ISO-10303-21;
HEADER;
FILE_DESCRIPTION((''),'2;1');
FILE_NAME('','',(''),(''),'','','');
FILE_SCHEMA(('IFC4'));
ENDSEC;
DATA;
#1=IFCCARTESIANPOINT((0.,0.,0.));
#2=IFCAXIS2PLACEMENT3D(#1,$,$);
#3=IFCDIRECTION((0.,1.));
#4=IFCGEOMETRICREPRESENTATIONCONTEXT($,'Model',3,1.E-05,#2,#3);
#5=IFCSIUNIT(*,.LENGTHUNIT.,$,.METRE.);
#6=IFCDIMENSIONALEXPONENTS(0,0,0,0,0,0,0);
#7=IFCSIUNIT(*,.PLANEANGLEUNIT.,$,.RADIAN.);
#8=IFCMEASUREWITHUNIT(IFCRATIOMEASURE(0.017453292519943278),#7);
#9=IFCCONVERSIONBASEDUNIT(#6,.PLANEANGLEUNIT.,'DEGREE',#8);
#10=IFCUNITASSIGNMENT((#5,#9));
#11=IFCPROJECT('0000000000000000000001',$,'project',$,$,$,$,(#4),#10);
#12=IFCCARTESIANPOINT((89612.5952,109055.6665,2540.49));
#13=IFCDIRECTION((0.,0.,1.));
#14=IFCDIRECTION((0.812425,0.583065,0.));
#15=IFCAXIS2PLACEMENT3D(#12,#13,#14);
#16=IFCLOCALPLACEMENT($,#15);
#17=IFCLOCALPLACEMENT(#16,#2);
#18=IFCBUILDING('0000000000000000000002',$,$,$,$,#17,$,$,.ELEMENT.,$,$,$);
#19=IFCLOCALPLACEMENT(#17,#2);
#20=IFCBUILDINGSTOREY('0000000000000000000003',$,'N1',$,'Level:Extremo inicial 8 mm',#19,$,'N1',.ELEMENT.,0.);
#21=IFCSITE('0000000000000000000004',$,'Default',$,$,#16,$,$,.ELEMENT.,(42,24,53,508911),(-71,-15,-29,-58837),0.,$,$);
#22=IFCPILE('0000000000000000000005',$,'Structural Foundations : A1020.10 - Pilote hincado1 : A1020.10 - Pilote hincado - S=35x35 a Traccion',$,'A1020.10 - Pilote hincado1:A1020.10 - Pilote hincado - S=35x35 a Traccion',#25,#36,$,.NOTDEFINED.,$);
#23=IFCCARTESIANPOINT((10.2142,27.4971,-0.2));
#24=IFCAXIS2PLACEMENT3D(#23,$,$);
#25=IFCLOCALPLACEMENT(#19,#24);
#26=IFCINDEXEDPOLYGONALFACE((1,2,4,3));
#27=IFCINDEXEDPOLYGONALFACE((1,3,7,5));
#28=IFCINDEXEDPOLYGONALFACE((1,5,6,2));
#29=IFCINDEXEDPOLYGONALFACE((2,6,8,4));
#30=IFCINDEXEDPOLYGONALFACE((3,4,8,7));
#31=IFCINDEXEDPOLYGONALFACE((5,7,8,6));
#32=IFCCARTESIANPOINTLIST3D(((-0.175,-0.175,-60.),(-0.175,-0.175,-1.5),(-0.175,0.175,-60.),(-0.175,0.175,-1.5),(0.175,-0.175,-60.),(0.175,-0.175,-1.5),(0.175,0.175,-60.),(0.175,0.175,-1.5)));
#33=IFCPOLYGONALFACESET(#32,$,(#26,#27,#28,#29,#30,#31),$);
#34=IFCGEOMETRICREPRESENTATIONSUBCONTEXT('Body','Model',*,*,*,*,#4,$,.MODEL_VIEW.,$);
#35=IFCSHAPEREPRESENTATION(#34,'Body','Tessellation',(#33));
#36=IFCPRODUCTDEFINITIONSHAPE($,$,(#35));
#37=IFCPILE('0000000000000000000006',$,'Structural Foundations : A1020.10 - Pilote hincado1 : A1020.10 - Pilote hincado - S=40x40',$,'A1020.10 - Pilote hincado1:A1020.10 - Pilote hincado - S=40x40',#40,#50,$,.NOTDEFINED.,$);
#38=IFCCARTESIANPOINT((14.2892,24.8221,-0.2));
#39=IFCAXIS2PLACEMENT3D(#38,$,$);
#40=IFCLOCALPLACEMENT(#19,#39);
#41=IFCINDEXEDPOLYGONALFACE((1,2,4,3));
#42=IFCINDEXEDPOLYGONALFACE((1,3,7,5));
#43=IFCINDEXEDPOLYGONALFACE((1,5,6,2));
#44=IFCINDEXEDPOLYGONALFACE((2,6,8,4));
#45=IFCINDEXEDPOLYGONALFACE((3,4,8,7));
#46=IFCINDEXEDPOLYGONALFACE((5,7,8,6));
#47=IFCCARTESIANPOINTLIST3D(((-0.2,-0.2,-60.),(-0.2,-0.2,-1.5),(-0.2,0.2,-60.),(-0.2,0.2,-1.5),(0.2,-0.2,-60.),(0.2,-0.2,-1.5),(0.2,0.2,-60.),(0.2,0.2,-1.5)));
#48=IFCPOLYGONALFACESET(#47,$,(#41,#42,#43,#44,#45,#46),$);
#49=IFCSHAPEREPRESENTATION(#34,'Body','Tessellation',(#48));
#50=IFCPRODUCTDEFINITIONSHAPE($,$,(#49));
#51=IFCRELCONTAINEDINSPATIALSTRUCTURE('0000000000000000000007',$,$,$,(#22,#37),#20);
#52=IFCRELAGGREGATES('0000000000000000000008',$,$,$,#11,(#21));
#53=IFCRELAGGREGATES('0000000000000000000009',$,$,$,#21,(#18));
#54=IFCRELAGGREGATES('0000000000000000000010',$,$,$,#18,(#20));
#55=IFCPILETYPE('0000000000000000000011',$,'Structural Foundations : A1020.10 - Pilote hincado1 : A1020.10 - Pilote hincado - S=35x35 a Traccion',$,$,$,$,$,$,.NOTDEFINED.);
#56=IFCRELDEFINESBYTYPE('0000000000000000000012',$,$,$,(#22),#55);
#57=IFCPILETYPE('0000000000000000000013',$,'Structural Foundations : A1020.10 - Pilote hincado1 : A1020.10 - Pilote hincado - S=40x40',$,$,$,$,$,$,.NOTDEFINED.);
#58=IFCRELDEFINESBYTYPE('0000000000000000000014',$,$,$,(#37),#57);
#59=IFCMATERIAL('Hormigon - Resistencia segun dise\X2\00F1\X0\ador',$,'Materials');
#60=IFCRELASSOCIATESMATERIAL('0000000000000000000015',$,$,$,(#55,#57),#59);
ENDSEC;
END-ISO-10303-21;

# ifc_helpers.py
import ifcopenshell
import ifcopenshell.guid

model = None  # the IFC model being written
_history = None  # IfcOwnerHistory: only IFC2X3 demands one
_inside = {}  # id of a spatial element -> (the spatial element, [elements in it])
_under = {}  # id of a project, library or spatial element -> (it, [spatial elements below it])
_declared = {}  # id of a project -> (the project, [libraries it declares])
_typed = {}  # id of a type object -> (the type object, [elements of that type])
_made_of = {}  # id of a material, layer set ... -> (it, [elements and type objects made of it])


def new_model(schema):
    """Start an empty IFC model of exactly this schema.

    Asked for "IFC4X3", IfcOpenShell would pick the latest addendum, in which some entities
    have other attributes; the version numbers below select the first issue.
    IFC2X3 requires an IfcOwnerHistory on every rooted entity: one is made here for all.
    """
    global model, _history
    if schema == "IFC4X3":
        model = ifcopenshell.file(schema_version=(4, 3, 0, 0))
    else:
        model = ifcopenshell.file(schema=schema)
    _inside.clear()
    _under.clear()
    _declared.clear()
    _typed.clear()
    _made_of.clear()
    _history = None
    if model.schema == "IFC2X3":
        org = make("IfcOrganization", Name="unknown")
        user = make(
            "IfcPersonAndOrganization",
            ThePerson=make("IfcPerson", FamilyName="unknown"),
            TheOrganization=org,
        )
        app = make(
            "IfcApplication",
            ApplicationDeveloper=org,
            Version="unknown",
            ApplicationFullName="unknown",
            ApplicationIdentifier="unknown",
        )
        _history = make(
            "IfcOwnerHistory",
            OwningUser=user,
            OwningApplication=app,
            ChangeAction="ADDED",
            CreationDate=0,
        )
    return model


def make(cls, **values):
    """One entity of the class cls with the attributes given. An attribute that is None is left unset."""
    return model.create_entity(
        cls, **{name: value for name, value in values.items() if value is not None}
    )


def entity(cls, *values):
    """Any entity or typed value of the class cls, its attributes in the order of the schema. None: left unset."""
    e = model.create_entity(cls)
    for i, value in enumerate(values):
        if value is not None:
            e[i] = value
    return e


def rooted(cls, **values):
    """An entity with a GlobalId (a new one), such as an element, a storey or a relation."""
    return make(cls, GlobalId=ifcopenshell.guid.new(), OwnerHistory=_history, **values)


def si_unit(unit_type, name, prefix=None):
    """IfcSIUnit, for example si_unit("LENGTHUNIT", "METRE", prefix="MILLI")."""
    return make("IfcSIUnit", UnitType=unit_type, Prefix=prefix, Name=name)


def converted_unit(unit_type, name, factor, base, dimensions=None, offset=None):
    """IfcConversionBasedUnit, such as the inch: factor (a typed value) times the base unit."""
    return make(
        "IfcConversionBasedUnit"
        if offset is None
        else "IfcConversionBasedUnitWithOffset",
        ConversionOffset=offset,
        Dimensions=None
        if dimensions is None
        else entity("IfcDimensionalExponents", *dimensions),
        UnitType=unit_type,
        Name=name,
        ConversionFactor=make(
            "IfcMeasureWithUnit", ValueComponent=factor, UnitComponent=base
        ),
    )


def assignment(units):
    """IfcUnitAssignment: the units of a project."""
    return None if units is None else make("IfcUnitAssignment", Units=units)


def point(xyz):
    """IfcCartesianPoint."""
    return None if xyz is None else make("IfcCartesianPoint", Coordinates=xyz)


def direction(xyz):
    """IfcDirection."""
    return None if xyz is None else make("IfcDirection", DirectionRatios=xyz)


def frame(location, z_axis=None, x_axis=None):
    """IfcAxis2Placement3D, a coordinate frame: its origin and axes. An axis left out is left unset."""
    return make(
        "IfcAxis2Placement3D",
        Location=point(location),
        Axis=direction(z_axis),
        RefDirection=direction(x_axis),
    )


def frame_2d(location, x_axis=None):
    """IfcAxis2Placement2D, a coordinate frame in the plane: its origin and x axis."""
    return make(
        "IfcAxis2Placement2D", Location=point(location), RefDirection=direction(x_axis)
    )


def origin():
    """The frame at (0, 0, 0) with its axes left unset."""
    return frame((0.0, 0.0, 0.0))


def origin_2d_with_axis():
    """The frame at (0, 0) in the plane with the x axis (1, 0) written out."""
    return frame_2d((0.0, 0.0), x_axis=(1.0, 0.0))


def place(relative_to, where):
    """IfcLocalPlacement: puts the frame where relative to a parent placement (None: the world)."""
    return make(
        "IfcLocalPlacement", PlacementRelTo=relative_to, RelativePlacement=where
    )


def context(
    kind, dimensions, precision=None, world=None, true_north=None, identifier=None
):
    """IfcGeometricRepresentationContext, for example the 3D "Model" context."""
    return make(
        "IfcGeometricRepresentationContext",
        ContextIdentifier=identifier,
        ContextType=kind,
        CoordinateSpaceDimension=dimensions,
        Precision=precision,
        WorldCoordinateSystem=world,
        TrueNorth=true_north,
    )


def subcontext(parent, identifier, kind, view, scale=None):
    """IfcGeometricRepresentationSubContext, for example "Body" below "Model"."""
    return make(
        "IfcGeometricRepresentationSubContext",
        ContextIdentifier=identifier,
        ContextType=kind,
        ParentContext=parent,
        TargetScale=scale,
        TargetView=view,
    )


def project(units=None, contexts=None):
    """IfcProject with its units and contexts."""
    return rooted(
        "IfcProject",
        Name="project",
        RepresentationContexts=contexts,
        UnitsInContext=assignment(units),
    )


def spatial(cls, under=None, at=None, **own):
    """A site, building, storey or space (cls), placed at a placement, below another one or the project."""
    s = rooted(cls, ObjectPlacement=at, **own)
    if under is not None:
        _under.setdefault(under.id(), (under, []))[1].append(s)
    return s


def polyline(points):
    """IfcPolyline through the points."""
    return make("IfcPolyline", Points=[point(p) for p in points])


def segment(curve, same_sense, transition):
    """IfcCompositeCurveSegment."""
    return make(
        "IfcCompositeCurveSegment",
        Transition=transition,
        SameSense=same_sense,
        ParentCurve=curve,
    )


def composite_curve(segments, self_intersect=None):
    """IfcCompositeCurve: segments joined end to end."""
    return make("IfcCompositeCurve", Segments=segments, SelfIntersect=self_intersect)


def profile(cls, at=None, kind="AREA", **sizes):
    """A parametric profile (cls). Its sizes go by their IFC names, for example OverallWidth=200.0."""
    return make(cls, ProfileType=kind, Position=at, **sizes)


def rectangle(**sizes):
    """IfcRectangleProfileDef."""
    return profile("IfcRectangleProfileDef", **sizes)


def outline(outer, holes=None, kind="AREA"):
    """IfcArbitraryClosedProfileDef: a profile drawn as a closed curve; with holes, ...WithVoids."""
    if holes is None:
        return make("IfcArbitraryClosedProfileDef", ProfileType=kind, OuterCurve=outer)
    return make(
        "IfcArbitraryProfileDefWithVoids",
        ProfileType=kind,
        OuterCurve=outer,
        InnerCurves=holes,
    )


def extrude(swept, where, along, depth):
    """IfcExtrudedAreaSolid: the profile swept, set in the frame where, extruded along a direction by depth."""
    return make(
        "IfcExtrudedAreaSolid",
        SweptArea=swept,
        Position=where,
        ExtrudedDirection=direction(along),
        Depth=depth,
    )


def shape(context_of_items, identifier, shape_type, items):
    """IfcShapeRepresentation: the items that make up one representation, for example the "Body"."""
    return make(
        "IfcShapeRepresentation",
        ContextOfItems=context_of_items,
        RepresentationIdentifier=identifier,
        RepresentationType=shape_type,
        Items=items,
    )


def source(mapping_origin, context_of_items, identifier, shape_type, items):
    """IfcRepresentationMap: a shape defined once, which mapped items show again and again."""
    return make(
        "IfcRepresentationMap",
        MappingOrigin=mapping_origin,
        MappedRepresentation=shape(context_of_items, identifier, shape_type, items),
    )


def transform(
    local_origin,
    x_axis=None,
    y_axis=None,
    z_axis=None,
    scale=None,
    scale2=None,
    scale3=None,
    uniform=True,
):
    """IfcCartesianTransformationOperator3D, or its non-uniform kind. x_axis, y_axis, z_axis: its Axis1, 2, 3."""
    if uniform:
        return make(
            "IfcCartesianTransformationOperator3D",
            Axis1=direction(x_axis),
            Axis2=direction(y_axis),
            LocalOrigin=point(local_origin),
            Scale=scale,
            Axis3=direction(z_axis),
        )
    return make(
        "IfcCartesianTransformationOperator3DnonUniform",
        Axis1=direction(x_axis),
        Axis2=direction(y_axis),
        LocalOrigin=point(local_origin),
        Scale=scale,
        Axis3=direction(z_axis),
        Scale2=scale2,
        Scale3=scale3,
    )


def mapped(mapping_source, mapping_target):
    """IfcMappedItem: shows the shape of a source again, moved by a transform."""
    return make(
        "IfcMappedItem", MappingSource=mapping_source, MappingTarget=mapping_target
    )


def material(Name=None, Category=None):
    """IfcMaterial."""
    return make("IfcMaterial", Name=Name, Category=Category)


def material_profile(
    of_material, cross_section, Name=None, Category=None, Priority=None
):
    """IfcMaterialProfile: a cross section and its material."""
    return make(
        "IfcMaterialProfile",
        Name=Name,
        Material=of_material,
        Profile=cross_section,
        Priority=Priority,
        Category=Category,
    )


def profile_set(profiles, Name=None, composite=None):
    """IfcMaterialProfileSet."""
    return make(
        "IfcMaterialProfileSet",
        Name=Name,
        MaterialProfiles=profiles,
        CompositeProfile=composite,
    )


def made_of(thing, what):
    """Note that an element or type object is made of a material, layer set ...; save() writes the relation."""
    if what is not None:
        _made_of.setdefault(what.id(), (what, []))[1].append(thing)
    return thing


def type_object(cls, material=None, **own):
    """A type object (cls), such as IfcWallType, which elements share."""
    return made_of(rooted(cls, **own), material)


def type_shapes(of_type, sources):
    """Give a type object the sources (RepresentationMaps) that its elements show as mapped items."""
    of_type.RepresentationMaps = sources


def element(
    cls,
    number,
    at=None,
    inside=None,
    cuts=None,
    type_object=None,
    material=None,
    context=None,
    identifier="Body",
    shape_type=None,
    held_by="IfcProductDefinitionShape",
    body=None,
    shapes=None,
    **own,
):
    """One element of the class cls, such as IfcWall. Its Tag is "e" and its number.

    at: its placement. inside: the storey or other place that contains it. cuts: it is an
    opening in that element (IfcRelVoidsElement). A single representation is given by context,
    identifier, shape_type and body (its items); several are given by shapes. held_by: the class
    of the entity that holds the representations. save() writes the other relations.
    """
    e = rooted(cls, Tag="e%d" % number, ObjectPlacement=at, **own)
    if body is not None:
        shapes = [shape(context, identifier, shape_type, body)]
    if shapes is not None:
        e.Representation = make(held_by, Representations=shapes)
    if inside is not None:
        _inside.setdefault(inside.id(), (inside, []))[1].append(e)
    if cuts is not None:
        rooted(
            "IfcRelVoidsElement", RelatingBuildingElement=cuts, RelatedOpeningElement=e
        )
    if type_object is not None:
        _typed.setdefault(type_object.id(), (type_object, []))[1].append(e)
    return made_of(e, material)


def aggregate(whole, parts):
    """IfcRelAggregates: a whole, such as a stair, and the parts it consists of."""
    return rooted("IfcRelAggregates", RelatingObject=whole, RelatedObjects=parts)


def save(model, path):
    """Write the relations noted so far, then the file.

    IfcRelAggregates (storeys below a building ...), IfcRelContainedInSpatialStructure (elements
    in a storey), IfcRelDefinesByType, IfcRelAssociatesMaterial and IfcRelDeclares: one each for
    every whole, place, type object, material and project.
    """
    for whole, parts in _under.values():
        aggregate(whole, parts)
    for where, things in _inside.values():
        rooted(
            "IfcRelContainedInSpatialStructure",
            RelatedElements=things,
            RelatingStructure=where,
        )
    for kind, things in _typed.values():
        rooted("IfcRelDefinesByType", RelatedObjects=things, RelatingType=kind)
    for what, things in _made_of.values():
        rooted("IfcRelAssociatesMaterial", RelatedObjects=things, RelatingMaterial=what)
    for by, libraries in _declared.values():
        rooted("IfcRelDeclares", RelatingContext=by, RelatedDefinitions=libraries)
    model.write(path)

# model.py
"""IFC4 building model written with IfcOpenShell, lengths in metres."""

from ifc_helpers import new_model, entity, si_unit, converted_unit, direction, frame, origin, origin_2d_with_axis, place, context, subcontext, project, spatial, polyline, segment, composite_curve, rectangle, outline, extrude, source, transform, mapped, material, material_profile, profile_set, type_object, type_shapes, element, save


model = new_model("IFC4")

# Units and contexts
model_context = context("Model", 3, precision=1e-05, world=origin(), true_north=direction((0.0, 1.0)))
body_context = subcontext(model_context, "Body", "Model", "MODEL_VIEW")
ifc_project = project(units=[si_unit("LENGTHUNIT", "METRE"), converted_unit("PLANEANGLEUNIT", "DEGREE", entity("IfcRatioMeasure", 0.017453292519943278), si_unit("PLANEANGLEUNIT", "RADIAN"), dimensions=[0, 0, 0, 0, 0, 0, 0])], contexts=[model_context])

# Site, building, storey
site_placement = place(None, frame((89612.5952, 109055.6665, 2540.49), z_axis=(0.0, 0.0, 1.0), x_axis=(0.812425, 0.583065, 0.0)))
site = spatial("IfcSite", under=ifc_project, at=site_placement, Name="Default", CompositionType="ELEMENT", RefLatitude=(42, 24, 53, 508911), RefLongitude=(-71, -15, -29, -58837), RefElevation=0.0)
building_placement = place(site_placement, origin())
building = spatial("IfcBuilding", under=site, at=building_placement, CompositionType="ELEMENT")
storey_placement = place(building_placement, origin())
storey = spatial("IfcBuildingStorey", under=building, at=storey_placement, Name="N1", ObjectType="Level:Extremo inicial 8 mm", LongName="N1", CompositionType="ELEMENT", Elevation=0.0)

# Piles
ifc_material_1 = material(Name="Hormigon - Resistencia segun diseñador", Category="Materials")
ifc_material_profile_1 = material_profile(ifc_material_1, outline(composite_curve([segment(polyline([(0.175, 0.175, -60.0), (0.175, -0.175, -60.0)]), True, "CONTINUOUS"), segment(polyline([(0.175, -0.175, -60.0), (-0.175, -0.175, -60.0)]), True, "CONTINUOUS"), segment(polyline([(-0.175, -0.175, -60.0), (-0.175, 0.175, -60.0)]), True, "CONTINUOUS"), segment(polyline([(-0.175, 0.175, -60.0), (0.175, 0.175, -60.0)]), True, "CONTINUOUS")], self_intersect=False), kind="CURVE"), Name="A1020.10 - Pilote hincado - S=35x35 a Traccion")
ifc_profile_set_1 = profile_set([ifc_material_profile_1], Name="A1020.10 - Pilote hincado - S=35x35 a Traccion")
pile_type_1 = type_object("IfcPileType", Name="Structural Foundations : A1020.10 - Pilote hincado1 : A1020.10 - Pilote hincado - S=35x35 a Traccion", PredefinedType="NOTDEFINED", material=ifc_profile_set_1)
shared_shape_1 = source(origin(), body_context, "Body", "SweptSolid", [
    extrude(rectangle(XDim=0.35, YDim=0.35, at=origin_2d_with_axis()), frame((0.0, 0.0, -60.0), z_axis=(0.0, 0.0, 1.0), x_axis=(0.0, -1.0, 0.0)), (0.0, 0.0, 1.0), 58.5),
])
type_shapes(pile_type_1, [shared_shape_1])
for number, where, name in (
    (1, (10.2142, 27.4971, -0.2), "Structural Foundations : A1020.10 - Pilote hincado1 : A1020.10 - Pilote hincado - S=35x35 a Traccion"),
):
    element("IfcPile", number, at=place(storey_placement, frame(where)), inside=storey, type_object=pile_type_1, Name=name, ObjectType="A1020.10 - Pilote hincado1:A1020.10 - Pilote hincado - S=35x35 a Traccion", PredefinedType="NOTDEFINED", context=body_context, shape_type="MappedRepresentation", body=[
        mapped(shared_shape_1, transform((0.0, 0.0, 0.0), scale=1.0)),
    ])
ifc_material_profile_2 = material_profile(ifc_material_1, outline(composite_curve([segment(polyline([(0.2, 0.2, -60.0), (0.2, -0.2, -60.0)]), True, "CONTINUOUS"), segment(polyline([(0.2, -0.2, -60.0), (-0.2, -0.2, -60.0)]), True, "CONTINUOUS"), segment(polyline([(-0.2, -0.2, -60.0), (-0.2, 0.2, -60.0)]), True, "CONTINUOUS"), segment(polyline([(-0.2, 0.2, -60.0), (0.2, 0.2, -60.0)]), True, "CONTINUOUS")], self_intersect=False), kind="CURVE"), Name="A1020.10 - Pilote hincado - S=40x40")
ifc_profile_set_2 = profile_set([ifc_material_profile_2], Name="A1020.10 - Pilote hincado - S=40x40")
pile_type_2 = type_object("IfcPileType", Name="Structural Foundations : A1020.10 - Pilote hincado1 : A1020.10 - Pilote hincado - S=40x40", PredefinedType="NOTDEFINED", material=ifc_profile_set_2)
shared_shape_2 = source(origin(), body_context, "Body", "SweptSolid", [
    extrude(rectangle(XDim=0.4, YDim=0.4, at=origin_2d_with_axis()), frame((0.0, 0.0, -60.0), z_axis=(0.0, 0.0, 1.0), x_axis=(0.0, -1.0, 0.0)), (0.0, 0.0, 1.0), 58.5),
])
type_shapes(pile_type_2, [shared_shape_2])
pile_placement = place(storey_placement, frame((14.2892, 24.8221, -0.2)))
element("IfcPile", 2, at=pile_placement, inside=storey, type_object=pile_type_2, Name="Structural Foundations : A1020.10 - Pilote hincado1 : A1020.10 - Pilote hincado - S=40x40", ObjectType="A1020.10 - Pilote hincado1:A1020.10 - Pilote hincado - S=40x40", PredefinedType="NOTDEFINED", context=body_context, shape_type="MappedRepresentation", body=[
    mapped(shared_shape_2, transform((0.0, 0.0, 0.0), scale=1.0)),
])

save(model, "model.ifc")
